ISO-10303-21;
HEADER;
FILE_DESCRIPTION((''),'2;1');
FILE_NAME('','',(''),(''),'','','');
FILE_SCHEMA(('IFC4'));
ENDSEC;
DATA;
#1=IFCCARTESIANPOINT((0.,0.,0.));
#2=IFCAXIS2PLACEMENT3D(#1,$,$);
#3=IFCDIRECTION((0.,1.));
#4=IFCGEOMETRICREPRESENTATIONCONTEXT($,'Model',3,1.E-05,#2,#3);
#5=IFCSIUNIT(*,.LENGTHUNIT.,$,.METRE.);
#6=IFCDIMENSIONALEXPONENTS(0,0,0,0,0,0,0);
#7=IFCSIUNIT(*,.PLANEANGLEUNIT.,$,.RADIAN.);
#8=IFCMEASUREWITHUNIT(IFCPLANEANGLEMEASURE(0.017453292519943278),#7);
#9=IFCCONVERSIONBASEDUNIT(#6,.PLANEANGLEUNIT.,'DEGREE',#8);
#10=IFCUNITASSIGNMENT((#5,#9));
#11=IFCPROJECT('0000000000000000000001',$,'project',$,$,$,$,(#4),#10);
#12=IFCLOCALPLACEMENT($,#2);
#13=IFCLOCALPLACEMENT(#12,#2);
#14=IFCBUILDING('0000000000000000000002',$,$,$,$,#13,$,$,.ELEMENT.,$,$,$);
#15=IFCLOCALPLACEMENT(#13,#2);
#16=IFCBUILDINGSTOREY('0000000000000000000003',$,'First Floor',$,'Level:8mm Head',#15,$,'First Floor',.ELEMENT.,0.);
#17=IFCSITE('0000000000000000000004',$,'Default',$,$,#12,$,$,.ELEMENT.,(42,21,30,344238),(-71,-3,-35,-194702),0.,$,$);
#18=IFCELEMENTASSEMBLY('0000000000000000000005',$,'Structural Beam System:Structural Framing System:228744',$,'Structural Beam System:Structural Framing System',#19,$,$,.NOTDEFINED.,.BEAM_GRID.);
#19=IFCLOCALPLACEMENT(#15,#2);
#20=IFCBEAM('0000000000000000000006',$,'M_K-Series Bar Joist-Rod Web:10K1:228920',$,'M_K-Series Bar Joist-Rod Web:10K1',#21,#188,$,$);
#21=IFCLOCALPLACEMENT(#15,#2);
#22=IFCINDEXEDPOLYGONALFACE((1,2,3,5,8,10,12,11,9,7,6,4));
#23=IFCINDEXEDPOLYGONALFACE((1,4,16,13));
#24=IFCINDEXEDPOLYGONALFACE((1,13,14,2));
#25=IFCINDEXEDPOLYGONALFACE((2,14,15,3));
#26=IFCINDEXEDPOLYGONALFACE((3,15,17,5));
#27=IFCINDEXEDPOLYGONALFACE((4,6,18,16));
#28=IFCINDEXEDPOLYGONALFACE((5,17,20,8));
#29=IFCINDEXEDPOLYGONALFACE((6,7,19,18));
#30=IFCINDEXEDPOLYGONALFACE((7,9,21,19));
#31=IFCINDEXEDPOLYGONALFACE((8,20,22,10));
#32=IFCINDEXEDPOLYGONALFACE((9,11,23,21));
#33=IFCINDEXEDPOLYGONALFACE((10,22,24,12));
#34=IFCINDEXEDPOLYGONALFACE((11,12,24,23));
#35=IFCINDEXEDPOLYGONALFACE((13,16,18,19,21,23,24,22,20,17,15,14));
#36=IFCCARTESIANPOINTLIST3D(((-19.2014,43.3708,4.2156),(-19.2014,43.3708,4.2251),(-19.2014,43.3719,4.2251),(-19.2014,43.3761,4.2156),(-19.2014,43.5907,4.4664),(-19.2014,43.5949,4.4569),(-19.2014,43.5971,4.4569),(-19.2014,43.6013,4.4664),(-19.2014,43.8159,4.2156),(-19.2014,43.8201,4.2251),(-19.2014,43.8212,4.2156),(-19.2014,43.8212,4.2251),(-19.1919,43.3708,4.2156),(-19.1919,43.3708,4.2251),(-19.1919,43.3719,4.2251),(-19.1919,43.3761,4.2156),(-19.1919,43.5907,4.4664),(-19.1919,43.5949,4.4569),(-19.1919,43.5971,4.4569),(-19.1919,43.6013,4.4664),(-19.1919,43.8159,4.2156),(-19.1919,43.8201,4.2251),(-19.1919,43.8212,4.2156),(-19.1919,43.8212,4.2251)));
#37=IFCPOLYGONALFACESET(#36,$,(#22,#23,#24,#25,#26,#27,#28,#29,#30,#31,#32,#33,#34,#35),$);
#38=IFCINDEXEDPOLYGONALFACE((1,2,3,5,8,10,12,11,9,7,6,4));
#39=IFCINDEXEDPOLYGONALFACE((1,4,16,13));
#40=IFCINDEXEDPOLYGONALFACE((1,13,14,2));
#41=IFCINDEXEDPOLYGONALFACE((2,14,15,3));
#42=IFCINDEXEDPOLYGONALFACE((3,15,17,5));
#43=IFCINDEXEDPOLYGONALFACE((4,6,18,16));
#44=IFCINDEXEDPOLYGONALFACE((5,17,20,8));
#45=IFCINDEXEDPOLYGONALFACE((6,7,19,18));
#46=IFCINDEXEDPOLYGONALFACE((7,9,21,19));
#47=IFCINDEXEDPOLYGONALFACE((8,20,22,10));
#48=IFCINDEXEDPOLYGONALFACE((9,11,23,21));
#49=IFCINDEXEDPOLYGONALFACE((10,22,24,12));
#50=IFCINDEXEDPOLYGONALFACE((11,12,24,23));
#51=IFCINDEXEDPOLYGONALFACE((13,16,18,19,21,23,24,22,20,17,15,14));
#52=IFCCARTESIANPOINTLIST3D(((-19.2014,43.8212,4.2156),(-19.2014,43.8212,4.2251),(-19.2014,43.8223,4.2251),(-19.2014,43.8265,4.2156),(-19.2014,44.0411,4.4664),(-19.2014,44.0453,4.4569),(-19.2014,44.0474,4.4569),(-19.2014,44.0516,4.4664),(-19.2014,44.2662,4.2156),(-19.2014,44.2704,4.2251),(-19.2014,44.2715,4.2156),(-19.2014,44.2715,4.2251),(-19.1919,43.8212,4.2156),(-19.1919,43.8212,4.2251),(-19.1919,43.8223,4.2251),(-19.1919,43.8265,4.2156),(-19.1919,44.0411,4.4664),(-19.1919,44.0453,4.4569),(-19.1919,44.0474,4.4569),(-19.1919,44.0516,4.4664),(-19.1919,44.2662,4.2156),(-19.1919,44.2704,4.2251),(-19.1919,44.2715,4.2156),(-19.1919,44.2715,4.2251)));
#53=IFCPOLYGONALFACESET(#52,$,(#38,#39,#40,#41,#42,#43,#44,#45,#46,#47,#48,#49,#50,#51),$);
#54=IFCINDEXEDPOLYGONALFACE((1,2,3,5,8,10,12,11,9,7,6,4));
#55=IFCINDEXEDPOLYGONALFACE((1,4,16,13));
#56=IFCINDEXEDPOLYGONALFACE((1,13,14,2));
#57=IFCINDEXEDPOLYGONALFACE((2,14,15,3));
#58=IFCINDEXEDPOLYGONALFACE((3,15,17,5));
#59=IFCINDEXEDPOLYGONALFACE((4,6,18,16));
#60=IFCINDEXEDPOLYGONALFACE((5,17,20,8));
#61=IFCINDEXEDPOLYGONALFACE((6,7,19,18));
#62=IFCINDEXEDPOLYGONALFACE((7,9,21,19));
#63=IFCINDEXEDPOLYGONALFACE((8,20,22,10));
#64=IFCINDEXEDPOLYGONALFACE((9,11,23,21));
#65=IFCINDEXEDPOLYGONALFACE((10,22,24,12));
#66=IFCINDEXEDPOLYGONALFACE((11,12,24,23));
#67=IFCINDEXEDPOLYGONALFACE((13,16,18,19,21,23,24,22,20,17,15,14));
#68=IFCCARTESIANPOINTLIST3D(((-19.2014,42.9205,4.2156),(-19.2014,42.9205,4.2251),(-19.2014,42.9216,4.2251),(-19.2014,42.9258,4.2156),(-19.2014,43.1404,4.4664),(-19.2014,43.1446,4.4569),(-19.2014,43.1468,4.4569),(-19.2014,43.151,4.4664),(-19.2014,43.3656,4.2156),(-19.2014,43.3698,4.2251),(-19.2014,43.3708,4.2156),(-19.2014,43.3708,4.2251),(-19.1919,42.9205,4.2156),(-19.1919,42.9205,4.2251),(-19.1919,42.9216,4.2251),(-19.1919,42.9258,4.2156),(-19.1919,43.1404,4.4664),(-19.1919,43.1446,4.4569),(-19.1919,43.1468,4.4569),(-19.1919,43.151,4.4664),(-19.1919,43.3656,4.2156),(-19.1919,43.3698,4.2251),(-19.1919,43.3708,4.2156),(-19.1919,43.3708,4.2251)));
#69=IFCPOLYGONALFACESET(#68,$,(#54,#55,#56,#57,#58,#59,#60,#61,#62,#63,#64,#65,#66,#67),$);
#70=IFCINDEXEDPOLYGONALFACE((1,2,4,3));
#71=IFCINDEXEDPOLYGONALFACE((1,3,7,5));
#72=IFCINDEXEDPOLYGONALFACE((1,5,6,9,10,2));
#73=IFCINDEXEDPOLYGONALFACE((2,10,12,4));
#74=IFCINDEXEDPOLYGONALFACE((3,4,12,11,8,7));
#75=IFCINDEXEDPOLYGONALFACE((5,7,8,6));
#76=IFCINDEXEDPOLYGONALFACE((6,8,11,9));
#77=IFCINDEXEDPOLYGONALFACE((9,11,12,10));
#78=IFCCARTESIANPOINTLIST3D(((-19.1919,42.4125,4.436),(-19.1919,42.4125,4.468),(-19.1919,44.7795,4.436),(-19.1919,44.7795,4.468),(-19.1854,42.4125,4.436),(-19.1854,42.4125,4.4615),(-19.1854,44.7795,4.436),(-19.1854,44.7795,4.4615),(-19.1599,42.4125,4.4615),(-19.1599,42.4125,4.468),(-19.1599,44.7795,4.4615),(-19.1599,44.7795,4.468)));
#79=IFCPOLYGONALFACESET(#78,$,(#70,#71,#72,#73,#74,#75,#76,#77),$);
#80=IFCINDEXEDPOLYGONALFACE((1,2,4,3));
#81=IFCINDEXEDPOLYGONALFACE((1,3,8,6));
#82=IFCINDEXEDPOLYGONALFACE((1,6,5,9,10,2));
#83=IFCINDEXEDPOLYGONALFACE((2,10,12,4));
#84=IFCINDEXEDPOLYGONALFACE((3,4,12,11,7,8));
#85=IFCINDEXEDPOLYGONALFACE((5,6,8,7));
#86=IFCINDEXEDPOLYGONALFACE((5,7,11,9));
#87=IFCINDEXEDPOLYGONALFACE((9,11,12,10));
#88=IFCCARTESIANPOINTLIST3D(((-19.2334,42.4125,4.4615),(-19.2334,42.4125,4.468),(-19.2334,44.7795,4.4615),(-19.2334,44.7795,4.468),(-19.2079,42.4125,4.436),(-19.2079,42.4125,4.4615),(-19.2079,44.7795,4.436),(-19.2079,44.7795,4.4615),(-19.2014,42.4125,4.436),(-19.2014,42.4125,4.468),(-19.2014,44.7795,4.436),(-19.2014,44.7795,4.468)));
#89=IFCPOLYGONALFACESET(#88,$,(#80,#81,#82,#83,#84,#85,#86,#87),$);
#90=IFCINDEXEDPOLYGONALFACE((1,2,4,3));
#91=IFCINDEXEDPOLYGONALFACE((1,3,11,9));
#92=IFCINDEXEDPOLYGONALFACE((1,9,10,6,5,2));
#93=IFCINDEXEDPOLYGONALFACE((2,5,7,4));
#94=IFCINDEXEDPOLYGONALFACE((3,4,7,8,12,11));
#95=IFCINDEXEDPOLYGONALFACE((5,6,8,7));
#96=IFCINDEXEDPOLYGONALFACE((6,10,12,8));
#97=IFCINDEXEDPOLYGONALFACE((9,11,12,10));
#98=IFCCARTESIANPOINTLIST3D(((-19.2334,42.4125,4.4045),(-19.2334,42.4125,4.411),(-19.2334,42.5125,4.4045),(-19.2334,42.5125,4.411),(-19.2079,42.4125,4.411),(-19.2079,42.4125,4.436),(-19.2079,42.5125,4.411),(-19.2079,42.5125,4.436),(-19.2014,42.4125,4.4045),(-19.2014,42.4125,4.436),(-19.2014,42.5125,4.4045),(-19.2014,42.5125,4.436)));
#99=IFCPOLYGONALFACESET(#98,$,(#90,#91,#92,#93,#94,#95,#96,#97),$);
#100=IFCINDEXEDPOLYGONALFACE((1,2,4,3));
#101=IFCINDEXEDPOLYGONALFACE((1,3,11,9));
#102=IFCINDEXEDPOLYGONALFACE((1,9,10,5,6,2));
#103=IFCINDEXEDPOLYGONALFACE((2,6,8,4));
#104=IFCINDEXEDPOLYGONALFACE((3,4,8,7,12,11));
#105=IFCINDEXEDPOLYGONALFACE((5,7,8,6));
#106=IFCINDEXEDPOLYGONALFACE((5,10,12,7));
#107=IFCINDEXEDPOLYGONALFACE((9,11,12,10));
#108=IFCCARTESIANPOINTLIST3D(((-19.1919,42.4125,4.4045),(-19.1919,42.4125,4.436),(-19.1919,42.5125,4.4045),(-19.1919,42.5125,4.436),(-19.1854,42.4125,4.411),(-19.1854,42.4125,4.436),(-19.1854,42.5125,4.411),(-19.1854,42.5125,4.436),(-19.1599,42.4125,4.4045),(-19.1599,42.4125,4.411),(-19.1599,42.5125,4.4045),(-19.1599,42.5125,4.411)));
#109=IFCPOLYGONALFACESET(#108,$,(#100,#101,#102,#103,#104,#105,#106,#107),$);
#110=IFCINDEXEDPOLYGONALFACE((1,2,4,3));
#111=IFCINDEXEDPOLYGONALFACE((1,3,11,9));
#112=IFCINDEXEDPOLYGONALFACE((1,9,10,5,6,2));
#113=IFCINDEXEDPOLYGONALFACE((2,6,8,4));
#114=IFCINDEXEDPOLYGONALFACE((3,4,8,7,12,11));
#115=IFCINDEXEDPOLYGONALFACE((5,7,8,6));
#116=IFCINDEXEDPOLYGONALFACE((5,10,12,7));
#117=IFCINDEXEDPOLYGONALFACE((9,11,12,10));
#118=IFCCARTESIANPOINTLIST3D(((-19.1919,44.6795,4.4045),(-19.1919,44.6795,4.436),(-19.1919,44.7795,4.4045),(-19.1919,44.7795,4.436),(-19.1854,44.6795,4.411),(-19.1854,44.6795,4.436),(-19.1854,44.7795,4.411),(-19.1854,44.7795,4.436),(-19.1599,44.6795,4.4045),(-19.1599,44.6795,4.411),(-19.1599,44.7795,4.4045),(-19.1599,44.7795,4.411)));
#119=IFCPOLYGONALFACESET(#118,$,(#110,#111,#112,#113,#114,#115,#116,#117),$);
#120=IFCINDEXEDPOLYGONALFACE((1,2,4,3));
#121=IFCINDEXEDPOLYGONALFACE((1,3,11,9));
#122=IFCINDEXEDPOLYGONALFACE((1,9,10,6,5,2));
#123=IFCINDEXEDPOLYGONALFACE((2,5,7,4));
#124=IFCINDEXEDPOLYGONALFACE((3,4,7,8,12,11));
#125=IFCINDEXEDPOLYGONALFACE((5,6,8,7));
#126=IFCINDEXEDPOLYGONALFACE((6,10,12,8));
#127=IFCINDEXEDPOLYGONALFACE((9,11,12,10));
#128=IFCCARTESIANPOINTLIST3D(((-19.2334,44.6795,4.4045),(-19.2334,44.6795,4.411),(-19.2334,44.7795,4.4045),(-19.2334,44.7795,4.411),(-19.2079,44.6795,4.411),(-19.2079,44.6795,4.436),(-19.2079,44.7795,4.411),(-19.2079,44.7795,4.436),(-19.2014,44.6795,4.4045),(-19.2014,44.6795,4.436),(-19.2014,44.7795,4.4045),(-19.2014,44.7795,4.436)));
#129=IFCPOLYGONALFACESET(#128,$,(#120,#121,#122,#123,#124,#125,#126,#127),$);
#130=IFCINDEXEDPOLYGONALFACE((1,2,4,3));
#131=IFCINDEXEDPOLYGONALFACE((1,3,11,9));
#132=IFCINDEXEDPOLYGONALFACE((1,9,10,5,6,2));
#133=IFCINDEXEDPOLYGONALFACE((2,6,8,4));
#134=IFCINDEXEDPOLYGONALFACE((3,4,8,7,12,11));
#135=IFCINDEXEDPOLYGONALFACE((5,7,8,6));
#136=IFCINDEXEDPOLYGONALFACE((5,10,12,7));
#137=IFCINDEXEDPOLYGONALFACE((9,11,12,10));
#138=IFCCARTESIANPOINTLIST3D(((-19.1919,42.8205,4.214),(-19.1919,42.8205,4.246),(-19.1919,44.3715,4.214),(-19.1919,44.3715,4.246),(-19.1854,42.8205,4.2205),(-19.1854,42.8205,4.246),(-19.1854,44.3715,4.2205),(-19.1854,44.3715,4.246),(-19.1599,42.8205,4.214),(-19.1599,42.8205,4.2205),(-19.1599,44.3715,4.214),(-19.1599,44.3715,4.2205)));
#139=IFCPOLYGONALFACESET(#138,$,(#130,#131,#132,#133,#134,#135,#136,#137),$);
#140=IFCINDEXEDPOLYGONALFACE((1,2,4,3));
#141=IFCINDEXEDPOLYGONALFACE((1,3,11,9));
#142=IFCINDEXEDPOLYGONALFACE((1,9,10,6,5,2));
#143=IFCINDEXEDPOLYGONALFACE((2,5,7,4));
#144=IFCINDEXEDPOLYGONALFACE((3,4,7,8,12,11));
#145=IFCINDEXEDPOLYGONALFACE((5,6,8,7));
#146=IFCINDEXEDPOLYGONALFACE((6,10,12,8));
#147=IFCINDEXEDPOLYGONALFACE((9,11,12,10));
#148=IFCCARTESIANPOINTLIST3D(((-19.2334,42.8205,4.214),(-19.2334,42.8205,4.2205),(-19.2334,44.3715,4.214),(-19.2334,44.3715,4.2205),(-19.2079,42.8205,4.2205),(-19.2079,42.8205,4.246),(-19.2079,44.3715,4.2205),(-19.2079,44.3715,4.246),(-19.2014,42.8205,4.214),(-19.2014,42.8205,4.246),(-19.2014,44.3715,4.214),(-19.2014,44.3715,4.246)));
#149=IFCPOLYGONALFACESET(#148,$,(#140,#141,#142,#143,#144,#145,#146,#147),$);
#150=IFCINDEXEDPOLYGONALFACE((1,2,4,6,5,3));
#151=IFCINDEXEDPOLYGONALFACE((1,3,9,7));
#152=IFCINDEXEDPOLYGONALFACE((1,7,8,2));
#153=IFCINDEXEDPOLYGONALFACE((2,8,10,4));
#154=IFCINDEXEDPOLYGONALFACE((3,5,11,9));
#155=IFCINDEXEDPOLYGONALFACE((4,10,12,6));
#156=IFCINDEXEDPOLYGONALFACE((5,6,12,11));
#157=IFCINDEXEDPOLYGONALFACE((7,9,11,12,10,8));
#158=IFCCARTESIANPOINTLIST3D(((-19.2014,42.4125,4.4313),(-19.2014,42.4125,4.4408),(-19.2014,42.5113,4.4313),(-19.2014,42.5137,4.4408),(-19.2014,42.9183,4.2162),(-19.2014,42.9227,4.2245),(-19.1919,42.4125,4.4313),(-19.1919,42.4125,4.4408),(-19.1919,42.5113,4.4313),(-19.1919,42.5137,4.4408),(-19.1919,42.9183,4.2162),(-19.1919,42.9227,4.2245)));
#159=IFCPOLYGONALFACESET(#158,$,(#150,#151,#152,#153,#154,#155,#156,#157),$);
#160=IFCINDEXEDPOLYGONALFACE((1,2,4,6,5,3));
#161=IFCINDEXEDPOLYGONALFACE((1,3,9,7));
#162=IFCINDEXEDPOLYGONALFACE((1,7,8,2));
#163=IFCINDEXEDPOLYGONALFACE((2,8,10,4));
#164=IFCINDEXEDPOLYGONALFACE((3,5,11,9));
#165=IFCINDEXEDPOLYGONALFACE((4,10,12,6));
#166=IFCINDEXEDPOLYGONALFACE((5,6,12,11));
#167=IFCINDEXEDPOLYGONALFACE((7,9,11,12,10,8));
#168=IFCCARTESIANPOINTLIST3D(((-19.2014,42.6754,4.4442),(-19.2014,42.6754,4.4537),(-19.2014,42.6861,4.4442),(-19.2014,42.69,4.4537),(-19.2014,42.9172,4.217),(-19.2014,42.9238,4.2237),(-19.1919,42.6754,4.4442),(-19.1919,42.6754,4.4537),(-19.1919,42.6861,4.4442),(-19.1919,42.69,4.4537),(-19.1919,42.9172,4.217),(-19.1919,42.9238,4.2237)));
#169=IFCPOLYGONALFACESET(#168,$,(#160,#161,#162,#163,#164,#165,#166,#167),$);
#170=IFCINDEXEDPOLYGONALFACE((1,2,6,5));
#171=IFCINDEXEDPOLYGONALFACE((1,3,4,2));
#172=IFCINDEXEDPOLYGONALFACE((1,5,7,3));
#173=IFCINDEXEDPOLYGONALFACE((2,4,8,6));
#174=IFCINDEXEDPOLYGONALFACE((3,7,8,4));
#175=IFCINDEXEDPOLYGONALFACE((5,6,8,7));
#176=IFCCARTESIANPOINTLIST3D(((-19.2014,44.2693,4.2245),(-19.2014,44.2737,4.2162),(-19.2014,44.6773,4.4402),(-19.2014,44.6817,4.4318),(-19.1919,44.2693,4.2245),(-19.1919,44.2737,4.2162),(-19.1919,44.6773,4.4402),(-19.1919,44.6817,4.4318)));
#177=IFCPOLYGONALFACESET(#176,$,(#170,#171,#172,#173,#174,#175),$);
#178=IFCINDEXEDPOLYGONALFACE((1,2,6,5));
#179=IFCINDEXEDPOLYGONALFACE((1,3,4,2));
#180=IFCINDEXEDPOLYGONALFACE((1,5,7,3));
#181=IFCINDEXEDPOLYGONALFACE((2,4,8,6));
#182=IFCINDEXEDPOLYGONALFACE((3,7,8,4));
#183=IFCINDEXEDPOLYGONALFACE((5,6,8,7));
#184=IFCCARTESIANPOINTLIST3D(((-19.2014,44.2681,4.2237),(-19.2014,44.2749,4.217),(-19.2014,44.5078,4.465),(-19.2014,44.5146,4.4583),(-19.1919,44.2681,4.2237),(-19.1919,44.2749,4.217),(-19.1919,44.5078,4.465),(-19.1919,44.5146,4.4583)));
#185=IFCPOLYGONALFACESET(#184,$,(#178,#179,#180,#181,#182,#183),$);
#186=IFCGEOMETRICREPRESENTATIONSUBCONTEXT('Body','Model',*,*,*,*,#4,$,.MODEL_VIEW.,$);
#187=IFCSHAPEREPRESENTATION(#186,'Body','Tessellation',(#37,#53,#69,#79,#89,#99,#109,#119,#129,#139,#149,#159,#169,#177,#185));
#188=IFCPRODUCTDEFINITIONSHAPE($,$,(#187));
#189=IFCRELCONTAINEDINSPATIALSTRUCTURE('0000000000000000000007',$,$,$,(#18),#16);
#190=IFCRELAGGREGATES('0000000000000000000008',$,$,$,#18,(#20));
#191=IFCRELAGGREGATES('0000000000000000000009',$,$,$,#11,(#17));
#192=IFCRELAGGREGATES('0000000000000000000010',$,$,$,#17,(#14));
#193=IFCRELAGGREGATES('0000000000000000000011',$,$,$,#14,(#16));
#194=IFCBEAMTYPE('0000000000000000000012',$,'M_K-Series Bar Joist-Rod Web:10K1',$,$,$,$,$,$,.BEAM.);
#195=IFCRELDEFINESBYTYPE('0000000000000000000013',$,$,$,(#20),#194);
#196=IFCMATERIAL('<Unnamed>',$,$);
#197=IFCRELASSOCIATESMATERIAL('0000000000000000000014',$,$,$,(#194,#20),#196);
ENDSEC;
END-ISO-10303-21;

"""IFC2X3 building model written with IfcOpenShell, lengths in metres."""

from ifc_helpers import new_model, entity, si_unit, converted_unit, direction, frame, frame_2d, origin, place, context, subcontext, project, spatial, polyline, rectangle, outline, extrude, source, transform, mapped, material, type_object, type_shapes, element, aggregate, save


model = new_model("IFC2X3")

# Units and contexts
model_context = context("Model", 3, precision=1e-05, world=origin(), true_north=direction((0.0, 1.0)))
body_context = subcontext(model_context, "Body", "Model", "MODEL_VIEW")
ifc_project = project(units=[si_unit("LENGTHUNIT", "METRE"), converted_unit("PLANEANGLEUNIT", "DEGREE", entity("IfcPlaneAngleMeasure", 0.017453292519943278), si_unit("PLANEANGLEUNIT", "RADIAN"), dimensions=[0, 0, 0, 0, 0, 0, 0])], contexts=[model_context])

# Site, building, storey
site_placement = place(None, origin())
site = spatial("IfcSite", under=ifc_project, at=site_placement, Name="Default", CompositionType="ELEMENT", RefLatitude=(42, 21, 30, 344238), RefLongitude=(-71, -3, -35, -194702), RefElevation=0.0)
building_placement = place(site_placement, origin())
building = spatial("IfcBuilding", under=site, at=building_placement, CompositionType="ELEMENT")
storey_placement = place(building_placement, origin())
storey = spatial("IfcBuildingStorey", under=building, at=storey_placement, Name="First Floor", ObjectType="Level:8mm Head", LongName="First Floor", CompositionType="ELEMENT", Elevation=0.0)

# Shared definitions
ifc_material_1 = material(Name="<Unnamed>")

# Element assembly, beam
assembly_1_placement = place(storey_placement, origin())
assembly_1 = element("IfcElementAssembly", 1, at=assembly_1_placement, inside=storey, Name="Structural Beam System:Structural Framing System:228744", ObjectType="Structural Beam System:Structural Framing System", AssemblyPlace="NOTDEFINED", PredefinedType="BEAM_GRID")
beam_type_1 = type_object("IfcBeamType", Name="M_K-Series Bar Joist-Rod Web:10K1", PredefinedType="BEAM", material=ifc_material_1)
shared_shape_1 = source(origin(), body_context, "Body", "SweptSolid", [
    extrude(outline(polyline([(-0.2252, -0.0757), (-0.2252, -0.0852), (-0.2199, -0.0852), (-0.0011, 0.1561), (0.0011, 0.1561), (0.2199, -0.0852), (0.2252, -0.0852), (0.2252, -0.0757), (0.2241, -0.0757), (0.0053, 0.1656), (-0.0053, 0.1656), (-0.2241, -0.0757), (-0.2252, -0.0757)])), frame((0.0, -0.0047, -0.0402), z_axis=(0.0, -1.0, 0.0), x_axis=(1.0, 0.0, 0.0)), (0.0, 0.0, -1.0), 0.0095),
    extrude(outline(polyline([(-0.2252, -0.0757), (-0.2252, -0.0852), (-0.2199, -0.0852), (-0.0011, 0.1561), (0.0011, 0.1561), (0.2199, -0.0852), (0.2252, -0.0852), (0.2252, -0.0757), (0.2241, -0.0757), (0.0053, 0.1656), (-0.0053, 0.1656), (-0.2241, -0.0757), (-0.2252, -0.0757)])), frame((0.4503, -0.0047, -0.0402), z_axis=(0.0, -1.0, 0.0), x_axis=(1.0, 0.0, 0.0)), (0.0, 0.0, -1.0), 0.0095),
    extrude(outline(polyline([(-0.2252, -0.0757), (-0.2252, -0.0852), (-0.2199, -0.0852), (-0.0011, 0.1561), (0.0011, 0.1561), (0.2199, -0.0852), (0.2252, -0.0852), (0.2252, -0.0757), (0.2241, -0.0757), (0.0053, 0.1656), (-0.0053, 0.1656), (-0.2241, -0.0757), (-0.2252, -0.0757)])), frame((-0.4503, -0.0047, -0.0402), z_axis=(0.0, -1.0, 0.0), x_axis=(1.0, 0.0, 0.0)), (0.0, 0.0, -1.0), 0.0095),
    extrude(outline(polyline([(-0.0128, -0.0128), (0.0192, -0.0128), (0.0192, -0.0063), (-0.0063, -0.0063), (-0.0063, 0.0192), (-0.0128, 0.0192), (-0.0128, -0.0128)])), frame((-1.1835, -0.0176, 0.1142), z_axis=(1.0, 0.0, 0.0), x_axis=(0.0, -1.0, 0.0)), (0.0, 0.0, 1.0), 2.367),
    extrude(outline(polyline([(-0.0128, -0.0128), (0.0192, -0.0128), (0.0192, -0.0063), (-0.0063, -0.0063), (-0.0063, 0.0192), (-0.0128, 0.0192), (-0.0128, -0.0128)])), frame((-1.1835, 0.0176, 0.1142), z_axis=(1.0, 0.0, 0.0), x_axis=(0.0, 0.0, -1.0)), (0.0, 0.0, 1.0), 2.367),
    extrude(outline(polyline([(-0.0127, -0.0192), (-0.0062, -0.0192), (-0.0062, 0.0063), (0.0188, 0.0063), (0.0188, 0.0128), (-0.0127, 0.0128), (-0.0127, -0.0192)])), frame((-1.1835, 0.0176, 0.0762), z_axis=(1.0, 0.0, 0.0), x_axis=(0.0, 0.0, 1.0)), (0.0, 0.0, 1.0), 0.1),
    extrude(outline(polyline([(-0.0127, -0.0128), (0.0188, -0.0128), (0.0188, -0.0063), (-0.0062, -0.0063), (-0.0062, 0.0192), (-0.0127, 0.0192), (-0.0127, -0.0128)])), frame((-1.1835, -0.0176, 0.0762), z_axis=(1.0, 0.0, 0.0), x_axis=(0.0, 0.0, 1.0)), (0.0, 0.0, 1.0), 0.1),
    extrude(outline(polyline([(-0.0127, -0.0128), (0.0188, -0.0128), (0.0188, -0.0063), (-0.0062, -0.0063), (-0.0062, 0.0192), (-0.0127, 0.0192), (-0.0127, -0.0128)])), frame((1.0835, -0.0176, 0.0762), z_axis=(1.0, 0.0, 0.0), x_axis=(0.0, 0.0, 1.0)), (0.0, 0.0, 1.0), 0.1),
    extrude(outline(polyline([(-0.0128, -0.0127), (0.0192, -0.0127), (0.0192, -0.0062), (-0.0063, -0.0062), (-0.0063, 0.0188), (-0.0128, 0.0188), (-0.0128, -0.0127)])), frame((1.0835, 0.0176, 0.0762), z_axis=(1.0, 0.0, 0.0), x_axis=(0.0, 1.0, 0.0)), (0.0, 0.0, 1.0), 0.1),
    extrude(outline(polyline([(-0.0128, -0.0128), (0.0192, -0.0128), (0.0192, -0.0063), (-0.0063, -0.0063), (-0.0063, 0.0192), (-0.0128, 0.0192), (-0.0128, -0.0128)])), frame((-0.7755, -0.0176, -0.1142), z_axis=(1.0, 0.0, 0.0), x_axis=(0.0, 0.0, 1.0)), (0.0, 0.0, 1.0), 1.551),
    extrude(outline(polyline([(-0.0128, -0.0128), (0.0192, -0.0128), (0.0192, -0.0063), (-0.0063, -0.0063), (-0.0063, 0.0192), (-0.0128, 0.0192), (-0.0128, -0.0128)])), frame((-0.7755, 0.0176, -0.1142), z_axis=(1.0, 0.0, 0.0), x_axis=(0.0, 1.0, 0.0)), (0.0, 0.0, 1.0), 1.551),
    extrude(outline(polyline([(-0.3371, -0.0108), (-0.3371, -0.0203), (0.1255, -0.0203), (0.215, 0.027), (0.2105, 0.0354), (0.1232, -0.0108), (-0.3371, -0.0108)])), frame((-0.9808, -0.0048, 0.0231), z_axis=(0.0, -1.0, 0.0), x_axis=(-0.884101, 0.0, 0.467295)), (0.0, 0.0, -1.0), 0.0095),
    extrude(outline(polyline([(-0.0859, -0.0809), (-0.0713, -0.0809), (0.1625, 0.149), (0.1559, 0.1558), (-0.0752, -0.0714), (-0.0859, -0.0714), (-0.0859, -0.0809)])), frame((-0.8347, -0.0047, 0.0318), z_axis=(0.0, 1.0, 0.0), x_axis=(1.0, 0.0, 0.0)), (0.0, 0.0, 1.0), 0.0095),
    extrude(rectangle(XDim=0.0095, YDim=0.0095, at=frame_2d((0.0, 0.0), x_axis=(0.0, 1.0))), frame((0.6755, 0.0, -0.1206), z_axis=(0.884101, 0.0, 0.467295), x_axis=(0.0, 1.0, 0.0)), (0.0, 0.0, 1.0), 0.4615),
    extrude(rectangle(XDim=0.3401, YDim=0.0095, at=frame_2d((0.0, 0.0), x_axis=(1.0, 0.0))), frame((0.7953, -0.0047, 0.0), z_axis=(0.0, 1.0, 0.0), x_axis=(-0.704723, 0.0, -0.709483)), (0.0, 0.0, 1.0), 0.0095),
])
type_shapes(beam_type_1, [shared_shape_1])
beam_1_placement = place(assembly_1_placement, frame((-19.1967, 43.596, 4.341), z_axis=(0.0, 0.0, 1.0), x_axis=(0.0, 1.0, 0.0)))
beam_1 = element("IfcBeam", 2, at=beam_1_placement, type_object=beam_type_1, material=ifc_material_1, Name="M_K-Series Bar Joist-Rod Web:10K1:228920", ObjectType="M_K-Series Bar Joist-Rod Web:10K1", context=body_context, shape_type="MappedRepresentation", body=[
    mapped(shared_shape_1, transform((0.0, 0.0, 0.0), scale=1.0)),
])
aggregate(assembly_1, [beam_1])

save(model, "model.ifc")
